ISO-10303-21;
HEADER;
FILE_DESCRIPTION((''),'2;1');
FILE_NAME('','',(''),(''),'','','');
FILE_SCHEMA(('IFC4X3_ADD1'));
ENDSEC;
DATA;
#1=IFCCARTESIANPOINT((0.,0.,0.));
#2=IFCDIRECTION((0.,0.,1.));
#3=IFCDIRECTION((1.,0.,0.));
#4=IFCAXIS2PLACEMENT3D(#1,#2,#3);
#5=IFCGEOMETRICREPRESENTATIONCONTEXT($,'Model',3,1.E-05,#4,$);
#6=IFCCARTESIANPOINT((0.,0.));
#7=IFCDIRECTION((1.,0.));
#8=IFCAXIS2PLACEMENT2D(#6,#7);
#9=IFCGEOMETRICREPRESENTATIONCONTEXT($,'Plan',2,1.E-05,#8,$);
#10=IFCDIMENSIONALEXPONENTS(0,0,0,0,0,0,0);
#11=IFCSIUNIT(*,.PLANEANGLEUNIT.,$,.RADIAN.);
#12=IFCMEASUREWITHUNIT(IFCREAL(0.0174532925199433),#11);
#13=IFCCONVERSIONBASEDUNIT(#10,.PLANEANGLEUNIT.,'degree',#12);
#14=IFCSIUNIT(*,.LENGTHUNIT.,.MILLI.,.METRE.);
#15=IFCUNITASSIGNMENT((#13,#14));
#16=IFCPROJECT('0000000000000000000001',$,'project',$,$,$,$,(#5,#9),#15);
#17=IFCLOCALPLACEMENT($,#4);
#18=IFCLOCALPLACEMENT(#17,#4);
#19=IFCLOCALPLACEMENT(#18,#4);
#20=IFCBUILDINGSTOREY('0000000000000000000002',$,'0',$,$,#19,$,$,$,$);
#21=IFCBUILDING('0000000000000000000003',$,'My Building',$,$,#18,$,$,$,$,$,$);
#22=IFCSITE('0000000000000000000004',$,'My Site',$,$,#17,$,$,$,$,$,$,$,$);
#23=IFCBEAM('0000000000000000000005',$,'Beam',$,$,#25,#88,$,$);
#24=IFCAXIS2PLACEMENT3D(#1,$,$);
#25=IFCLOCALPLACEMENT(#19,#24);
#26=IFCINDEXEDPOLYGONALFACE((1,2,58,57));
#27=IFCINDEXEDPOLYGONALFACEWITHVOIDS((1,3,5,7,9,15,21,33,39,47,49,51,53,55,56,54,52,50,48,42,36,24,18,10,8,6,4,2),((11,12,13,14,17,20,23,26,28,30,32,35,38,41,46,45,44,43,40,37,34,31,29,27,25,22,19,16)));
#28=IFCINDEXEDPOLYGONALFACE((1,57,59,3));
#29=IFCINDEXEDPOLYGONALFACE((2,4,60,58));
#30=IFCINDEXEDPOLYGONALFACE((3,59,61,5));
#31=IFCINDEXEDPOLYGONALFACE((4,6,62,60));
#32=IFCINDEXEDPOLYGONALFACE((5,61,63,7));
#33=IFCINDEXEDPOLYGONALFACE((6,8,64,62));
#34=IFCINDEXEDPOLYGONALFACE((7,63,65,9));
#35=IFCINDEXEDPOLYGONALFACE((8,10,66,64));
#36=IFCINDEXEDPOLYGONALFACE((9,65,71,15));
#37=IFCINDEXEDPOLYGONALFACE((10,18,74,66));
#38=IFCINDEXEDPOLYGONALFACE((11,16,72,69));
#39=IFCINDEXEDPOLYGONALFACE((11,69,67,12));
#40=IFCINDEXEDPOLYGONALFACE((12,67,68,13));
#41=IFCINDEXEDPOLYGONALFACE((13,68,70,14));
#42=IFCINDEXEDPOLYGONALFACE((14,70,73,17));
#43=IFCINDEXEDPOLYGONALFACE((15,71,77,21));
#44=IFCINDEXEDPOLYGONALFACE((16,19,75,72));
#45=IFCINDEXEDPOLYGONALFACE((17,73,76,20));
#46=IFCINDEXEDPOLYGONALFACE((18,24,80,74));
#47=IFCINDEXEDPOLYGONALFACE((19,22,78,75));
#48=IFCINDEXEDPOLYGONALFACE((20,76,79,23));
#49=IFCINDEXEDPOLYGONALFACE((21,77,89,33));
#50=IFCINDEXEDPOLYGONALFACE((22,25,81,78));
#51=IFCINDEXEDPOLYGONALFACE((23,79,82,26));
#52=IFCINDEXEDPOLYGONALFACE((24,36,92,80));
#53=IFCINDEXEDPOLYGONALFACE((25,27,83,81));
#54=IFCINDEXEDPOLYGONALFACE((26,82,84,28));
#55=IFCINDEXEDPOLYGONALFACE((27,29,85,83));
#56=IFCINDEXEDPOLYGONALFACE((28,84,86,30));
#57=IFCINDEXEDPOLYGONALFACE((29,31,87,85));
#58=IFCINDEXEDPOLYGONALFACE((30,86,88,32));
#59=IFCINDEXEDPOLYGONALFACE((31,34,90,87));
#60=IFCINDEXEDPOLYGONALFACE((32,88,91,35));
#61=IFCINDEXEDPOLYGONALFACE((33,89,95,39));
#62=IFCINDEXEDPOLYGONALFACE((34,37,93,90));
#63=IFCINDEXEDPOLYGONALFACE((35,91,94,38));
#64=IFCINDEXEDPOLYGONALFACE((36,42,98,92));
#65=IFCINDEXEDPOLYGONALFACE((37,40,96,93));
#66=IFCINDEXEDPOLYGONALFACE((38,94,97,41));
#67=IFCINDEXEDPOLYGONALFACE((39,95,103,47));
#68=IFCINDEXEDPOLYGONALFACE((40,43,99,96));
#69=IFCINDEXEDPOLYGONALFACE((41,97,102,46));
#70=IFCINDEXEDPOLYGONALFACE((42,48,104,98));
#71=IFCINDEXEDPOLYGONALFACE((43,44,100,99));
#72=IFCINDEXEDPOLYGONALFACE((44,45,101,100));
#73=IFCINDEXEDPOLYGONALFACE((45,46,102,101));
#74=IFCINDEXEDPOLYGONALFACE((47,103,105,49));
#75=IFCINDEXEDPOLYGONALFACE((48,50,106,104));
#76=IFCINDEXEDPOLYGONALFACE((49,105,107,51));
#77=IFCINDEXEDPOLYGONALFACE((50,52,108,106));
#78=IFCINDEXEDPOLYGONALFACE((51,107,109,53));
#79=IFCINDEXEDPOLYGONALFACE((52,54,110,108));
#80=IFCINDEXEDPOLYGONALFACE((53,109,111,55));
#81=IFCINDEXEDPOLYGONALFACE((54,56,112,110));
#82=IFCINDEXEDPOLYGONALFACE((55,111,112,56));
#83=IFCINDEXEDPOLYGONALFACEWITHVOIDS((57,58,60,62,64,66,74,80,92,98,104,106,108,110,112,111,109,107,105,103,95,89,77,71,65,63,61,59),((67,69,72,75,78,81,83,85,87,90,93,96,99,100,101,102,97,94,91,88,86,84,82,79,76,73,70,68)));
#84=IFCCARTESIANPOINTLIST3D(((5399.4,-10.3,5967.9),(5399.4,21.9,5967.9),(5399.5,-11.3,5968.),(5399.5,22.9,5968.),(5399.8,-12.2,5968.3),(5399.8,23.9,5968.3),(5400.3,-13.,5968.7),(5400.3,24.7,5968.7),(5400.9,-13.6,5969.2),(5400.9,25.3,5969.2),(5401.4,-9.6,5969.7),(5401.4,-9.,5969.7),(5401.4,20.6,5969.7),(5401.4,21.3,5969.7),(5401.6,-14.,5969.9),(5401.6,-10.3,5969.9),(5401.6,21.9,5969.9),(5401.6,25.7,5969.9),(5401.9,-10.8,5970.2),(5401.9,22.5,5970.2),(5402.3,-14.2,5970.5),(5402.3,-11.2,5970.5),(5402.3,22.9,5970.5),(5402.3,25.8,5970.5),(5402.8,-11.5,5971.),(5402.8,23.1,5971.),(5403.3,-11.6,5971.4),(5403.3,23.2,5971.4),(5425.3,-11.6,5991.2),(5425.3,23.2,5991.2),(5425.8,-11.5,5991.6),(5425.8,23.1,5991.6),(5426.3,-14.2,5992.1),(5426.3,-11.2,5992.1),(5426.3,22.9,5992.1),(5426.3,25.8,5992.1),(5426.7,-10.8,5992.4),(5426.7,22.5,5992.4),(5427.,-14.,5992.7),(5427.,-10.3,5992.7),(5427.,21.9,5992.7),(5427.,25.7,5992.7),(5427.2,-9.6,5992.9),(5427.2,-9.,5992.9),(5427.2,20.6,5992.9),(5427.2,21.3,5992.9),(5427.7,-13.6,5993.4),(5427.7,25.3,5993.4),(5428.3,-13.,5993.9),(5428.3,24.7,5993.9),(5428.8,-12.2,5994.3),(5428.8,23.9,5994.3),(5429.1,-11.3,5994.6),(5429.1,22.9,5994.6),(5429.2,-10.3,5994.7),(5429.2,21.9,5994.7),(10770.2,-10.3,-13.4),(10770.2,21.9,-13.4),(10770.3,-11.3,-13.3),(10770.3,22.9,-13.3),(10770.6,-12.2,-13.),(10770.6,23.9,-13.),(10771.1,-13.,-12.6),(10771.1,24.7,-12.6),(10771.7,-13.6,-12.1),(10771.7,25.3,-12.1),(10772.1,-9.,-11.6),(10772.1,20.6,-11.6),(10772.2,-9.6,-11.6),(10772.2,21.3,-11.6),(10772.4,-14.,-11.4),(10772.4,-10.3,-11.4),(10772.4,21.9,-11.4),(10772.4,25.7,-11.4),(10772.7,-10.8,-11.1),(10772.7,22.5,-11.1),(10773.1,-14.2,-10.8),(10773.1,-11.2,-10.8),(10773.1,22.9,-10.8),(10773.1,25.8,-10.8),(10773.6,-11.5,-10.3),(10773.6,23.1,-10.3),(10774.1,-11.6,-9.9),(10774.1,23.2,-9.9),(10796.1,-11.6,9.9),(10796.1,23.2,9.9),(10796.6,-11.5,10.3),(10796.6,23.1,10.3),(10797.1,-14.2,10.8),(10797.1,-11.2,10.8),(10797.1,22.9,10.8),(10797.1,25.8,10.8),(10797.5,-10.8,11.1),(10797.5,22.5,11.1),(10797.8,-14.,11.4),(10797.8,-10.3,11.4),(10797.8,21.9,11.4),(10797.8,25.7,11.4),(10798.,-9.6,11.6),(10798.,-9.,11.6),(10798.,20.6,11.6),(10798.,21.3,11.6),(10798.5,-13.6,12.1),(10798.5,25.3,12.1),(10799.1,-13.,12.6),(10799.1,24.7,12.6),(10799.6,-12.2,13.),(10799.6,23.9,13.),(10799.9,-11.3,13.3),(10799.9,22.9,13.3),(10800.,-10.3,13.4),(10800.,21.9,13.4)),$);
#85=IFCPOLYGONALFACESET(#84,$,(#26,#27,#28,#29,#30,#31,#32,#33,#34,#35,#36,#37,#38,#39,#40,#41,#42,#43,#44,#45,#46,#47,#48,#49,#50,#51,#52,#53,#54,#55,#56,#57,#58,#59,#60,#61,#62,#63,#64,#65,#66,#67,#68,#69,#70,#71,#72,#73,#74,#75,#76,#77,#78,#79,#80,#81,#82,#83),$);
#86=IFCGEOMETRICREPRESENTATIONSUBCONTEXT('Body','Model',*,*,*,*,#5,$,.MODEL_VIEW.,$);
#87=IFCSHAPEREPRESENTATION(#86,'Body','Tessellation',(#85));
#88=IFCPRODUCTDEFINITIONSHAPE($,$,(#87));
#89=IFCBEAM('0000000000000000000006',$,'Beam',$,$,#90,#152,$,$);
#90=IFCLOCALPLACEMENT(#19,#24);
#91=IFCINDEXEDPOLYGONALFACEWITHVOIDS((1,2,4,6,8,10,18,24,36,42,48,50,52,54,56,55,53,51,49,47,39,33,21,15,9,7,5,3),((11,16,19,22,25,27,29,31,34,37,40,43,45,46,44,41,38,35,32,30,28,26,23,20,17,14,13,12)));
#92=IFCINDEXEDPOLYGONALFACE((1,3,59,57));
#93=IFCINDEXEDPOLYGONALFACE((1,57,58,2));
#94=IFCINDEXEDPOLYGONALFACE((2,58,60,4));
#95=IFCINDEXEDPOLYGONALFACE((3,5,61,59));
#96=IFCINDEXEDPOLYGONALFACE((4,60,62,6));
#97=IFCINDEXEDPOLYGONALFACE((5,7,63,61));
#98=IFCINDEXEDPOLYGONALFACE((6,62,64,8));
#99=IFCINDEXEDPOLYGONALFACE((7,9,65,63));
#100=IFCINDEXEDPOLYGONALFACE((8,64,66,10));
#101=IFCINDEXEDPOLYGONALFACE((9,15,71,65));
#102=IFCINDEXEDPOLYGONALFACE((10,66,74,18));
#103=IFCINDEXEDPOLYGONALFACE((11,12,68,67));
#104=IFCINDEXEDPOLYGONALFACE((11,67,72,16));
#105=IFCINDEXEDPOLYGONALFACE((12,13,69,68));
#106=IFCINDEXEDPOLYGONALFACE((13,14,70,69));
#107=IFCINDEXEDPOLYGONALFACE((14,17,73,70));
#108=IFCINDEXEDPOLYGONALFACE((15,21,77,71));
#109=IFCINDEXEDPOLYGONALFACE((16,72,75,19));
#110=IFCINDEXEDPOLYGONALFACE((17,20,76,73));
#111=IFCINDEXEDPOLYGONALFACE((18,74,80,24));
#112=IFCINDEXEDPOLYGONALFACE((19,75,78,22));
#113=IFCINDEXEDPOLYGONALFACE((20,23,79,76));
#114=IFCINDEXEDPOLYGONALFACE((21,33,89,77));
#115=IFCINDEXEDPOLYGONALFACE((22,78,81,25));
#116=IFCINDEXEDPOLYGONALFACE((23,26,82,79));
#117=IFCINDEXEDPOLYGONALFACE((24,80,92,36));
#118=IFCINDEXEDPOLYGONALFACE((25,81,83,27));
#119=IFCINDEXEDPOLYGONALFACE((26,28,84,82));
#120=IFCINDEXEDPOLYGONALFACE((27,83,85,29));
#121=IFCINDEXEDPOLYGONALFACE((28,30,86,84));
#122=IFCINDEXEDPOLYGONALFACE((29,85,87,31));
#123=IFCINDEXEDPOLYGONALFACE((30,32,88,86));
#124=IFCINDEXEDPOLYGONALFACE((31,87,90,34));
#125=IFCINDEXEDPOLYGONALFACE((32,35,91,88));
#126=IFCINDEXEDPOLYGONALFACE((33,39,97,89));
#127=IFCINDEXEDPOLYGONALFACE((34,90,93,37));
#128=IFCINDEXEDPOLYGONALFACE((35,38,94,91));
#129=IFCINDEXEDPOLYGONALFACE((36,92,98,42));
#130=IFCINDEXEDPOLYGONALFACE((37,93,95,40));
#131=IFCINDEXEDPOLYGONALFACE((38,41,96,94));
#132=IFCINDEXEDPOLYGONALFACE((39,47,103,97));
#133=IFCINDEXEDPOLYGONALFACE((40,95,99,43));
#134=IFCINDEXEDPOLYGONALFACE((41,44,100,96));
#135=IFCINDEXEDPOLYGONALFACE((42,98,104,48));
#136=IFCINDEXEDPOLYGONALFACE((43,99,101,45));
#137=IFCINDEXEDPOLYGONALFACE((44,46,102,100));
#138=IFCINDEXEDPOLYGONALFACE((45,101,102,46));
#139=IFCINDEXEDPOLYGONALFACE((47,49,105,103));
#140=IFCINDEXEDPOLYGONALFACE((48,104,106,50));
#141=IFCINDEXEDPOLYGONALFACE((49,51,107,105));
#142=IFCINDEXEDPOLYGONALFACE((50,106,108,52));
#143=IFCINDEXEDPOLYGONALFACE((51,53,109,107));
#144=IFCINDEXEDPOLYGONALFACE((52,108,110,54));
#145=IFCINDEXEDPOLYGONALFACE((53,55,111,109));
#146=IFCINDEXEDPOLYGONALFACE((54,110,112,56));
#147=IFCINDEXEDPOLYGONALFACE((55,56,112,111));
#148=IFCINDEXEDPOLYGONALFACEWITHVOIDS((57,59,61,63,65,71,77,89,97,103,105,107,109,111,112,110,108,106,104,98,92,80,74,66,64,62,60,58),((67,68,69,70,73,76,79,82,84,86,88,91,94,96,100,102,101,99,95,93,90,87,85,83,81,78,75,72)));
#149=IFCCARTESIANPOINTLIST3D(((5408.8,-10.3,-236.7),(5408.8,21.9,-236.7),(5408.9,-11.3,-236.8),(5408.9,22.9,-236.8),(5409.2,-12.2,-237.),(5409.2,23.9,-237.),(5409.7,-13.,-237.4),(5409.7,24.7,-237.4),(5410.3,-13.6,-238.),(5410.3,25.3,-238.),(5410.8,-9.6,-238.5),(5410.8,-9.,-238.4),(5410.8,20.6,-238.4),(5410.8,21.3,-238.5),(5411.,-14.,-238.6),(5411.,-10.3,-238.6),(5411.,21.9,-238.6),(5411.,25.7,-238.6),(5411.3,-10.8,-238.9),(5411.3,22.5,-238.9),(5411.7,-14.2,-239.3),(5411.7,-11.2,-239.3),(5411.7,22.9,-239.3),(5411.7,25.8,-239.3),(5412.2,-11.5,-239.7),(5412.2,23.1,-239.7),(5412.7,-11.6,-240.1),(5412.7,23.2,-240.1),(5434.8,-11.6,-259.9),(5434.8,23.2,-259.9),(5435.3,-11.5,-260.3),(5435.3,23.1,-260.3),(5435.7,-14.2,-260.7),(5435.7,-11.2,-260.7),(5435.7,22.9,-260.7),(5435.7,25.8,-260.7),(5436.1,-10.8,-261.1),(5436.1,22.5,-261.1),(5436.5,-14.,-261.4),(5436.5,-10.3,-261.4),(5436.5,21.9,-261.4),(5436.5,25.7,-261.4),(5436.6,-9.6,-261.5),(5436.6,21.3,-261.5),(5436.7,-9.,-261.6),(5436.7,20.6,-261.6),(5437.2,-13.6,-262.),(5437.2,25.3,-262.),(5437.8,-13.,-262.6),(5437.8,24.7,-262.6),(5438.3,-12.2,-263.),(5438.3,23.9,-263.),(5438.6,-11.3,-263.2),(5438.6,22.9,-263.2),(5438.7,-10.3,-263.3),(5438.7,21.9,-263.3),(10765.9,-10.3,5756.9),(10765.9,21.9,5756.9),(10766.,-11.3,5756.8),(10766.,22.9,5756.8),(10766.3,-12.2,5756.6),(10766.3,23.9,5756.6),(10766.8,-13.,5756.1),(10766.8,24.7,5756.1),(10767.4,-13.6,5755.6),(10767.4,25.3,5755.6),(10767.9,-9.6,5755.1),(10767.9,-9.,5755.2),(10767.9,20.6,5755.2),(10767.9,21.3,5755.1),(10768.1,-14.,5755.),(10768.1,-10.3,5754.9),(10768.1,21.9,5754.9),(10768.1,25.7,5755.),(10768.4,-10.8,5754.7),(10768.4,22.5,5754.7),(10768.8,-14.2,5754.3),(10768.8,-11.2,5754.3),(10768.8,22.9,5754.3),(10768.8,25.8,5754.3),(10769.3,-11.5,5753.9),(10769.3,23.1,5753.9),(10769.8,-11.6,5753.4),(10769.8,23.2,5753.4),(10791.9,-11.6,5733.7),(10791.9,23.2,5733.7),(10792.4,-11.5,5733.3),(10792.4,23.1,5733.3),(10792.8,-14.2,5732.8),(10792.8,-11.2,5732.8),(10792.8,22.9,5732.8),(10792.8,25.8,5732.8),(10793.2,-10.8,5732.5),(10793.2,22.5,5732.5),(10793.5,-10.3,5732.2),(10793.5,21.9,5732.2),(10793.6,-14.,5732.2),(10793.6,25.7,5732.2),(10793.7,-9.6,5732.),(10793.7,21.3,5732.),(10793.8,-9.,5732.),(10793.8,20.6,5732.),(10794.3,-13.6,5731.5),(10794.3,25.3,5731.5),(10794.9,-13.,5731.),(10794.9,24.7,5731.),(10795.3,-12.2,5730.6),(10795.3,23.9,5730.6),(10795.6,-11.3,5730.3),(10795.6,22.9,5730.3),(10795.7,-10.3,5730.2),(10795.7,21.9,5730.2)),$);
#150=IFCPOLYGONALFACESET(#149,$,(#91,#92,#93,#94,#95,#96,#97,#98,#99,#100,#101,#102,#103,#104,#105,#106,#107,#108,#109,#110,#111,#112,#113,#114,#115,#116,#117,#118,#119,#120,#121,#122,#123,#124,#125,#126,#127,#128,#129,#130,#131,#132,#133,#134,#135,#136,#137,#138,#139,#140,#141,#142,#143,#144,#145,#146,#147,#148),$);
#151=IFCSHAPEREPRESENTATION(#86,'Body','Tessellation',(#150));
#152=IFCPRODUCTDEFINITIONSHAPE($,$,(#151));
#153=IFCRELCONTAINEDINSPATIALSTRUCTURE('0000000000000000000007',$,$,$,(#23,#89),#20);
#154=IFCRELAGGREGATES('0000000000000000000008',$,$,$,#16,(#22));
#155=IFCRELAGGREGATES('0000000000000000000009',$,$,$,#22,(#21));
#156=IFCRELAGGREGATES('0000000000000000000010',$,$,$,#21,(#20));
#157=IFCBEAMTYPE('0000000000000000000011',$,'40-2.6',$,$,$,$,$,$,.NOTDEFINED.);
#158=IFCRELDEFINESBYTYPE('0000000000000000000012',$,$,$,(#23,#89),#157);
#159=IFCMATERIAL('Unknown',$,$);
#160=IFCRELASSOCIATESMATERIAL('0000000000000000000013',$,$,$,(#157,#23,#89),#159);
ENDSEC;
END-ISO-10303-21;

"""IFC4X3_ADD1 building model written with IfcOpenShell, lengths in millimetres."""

from ifc_helpers import new_model, entity, si_unit, converted_unit, frame, origin_with_axes, origin_2d_with_axis, place, context, subcontext, project, spatial, hollow_rectangle, extrude, material, material_profile, profile_set, profile_usage, type_object, element, save


model = new_model("IFC4X3_ADD1")

# Units and contexts
model_context = context("Model", 3, precision=1e-05, world=origin_with_axes())
plan_context = context("Plan", 2, precision=1e-05, world=origin_2d_with_axis())
body_context = subcontext(model_context, "Body", "Model", "MODEL_VIEW")
ifc_project = project(units=[converted_unit("PLANEANGLEUNIT", "degree", entity("IfcReal", 0.0174532925199433), si_unit("PLANEANGLEUNIT", "RADIAN"), dimensions=[0, 0, 0, 0, 0, 0, 0]), si_unit("LENGTHUNIT", "METRE", prefix="MILLI")], contexts=[model_context, plan_context])

# Site, building, storey
site_placement = place(None, origin_with_axes())
site = spatial("IfcSite", under=ifc_project, at=site_placement, Name="My Site")
building_placement = place(site_placement, origin_with_axes())
building = spatial("IfcBuilding", under=site, at=building_placement, Name="My Building")
storey_placement = place(building_placement, origin_with_axes())
storey = spatial("IfcBuildingStorey", under=building, at=storey_placement, Name="0")

# Shared definitions
ifc_material = material(Name="Unknown")

# Beams
ifc_material_profile_1 = material_profile(ifc_material, hollow_rectangle(XDim=40.0, YDim=40.0, WallThickness=2.6, InnerFilletRadius=2.6, OuterFilletRadius=3.9))
ifc_profile_set_1 = profile_set([ifc_material_profile_1])
beam_type = type_object("IfcBeamType", Name="40-2.6", PredefinedType="NOTDEFINED", material=ifc_profile_set_1)
ifc_profile_usage_1 = profile_usage(ifc_profile_set_1, cardinal=5)
beam_1_placement = place(storey_placement, frame((10785.1, 5.8, 0.0), z_axis=(-0.668113, 0.0, 0.74406), x_axis=(0.0, 1.0, 0.0)))
element("IfcBeam", 1, at=beam_1_placement, inside=storey, type_object=beam_type, material=ifc_profile_usage_1, Name="Beam", context=body_context, shape_type="SweptSolid", body=[
    extrude(hollow_rectangle(XDim=40.0, YDim=40.0, WallThickness=2.6, InnerFilletRadius=2.6, OuterFilletRadius=3.9), origin_with_axes(), (0.0, 0.0, 1.0), 8038.7),
])
ifc_profile_usage_2 = profile_usage(ifc_profile_set_1, cardinal=5)
beam_2_placement = place(storey_placement, frame((5423.7, 5.8, -250.0), z_axis=(0.666409, 0.0, 0.745587), x_axis=(0.0, 1.0, 0.0)))
element("IfcBeam", 2, at=beam_2_placement, inside=storey, type_object=beam_type, material=ifc_profile_usage_2, Name="Beam", context=body_context, shape_type="SweptSolid", body=[
    extrude(hollow_rectangle(XDim=40.0, YDim=40.0, WallThickness=2.6, InnerFilletRadius=2.6, OuterFilletRadius=3.9), origin_with_axes(), (0.0, 0.0, 1.0), 8038.7),
])

save(model, "model.ifc")
